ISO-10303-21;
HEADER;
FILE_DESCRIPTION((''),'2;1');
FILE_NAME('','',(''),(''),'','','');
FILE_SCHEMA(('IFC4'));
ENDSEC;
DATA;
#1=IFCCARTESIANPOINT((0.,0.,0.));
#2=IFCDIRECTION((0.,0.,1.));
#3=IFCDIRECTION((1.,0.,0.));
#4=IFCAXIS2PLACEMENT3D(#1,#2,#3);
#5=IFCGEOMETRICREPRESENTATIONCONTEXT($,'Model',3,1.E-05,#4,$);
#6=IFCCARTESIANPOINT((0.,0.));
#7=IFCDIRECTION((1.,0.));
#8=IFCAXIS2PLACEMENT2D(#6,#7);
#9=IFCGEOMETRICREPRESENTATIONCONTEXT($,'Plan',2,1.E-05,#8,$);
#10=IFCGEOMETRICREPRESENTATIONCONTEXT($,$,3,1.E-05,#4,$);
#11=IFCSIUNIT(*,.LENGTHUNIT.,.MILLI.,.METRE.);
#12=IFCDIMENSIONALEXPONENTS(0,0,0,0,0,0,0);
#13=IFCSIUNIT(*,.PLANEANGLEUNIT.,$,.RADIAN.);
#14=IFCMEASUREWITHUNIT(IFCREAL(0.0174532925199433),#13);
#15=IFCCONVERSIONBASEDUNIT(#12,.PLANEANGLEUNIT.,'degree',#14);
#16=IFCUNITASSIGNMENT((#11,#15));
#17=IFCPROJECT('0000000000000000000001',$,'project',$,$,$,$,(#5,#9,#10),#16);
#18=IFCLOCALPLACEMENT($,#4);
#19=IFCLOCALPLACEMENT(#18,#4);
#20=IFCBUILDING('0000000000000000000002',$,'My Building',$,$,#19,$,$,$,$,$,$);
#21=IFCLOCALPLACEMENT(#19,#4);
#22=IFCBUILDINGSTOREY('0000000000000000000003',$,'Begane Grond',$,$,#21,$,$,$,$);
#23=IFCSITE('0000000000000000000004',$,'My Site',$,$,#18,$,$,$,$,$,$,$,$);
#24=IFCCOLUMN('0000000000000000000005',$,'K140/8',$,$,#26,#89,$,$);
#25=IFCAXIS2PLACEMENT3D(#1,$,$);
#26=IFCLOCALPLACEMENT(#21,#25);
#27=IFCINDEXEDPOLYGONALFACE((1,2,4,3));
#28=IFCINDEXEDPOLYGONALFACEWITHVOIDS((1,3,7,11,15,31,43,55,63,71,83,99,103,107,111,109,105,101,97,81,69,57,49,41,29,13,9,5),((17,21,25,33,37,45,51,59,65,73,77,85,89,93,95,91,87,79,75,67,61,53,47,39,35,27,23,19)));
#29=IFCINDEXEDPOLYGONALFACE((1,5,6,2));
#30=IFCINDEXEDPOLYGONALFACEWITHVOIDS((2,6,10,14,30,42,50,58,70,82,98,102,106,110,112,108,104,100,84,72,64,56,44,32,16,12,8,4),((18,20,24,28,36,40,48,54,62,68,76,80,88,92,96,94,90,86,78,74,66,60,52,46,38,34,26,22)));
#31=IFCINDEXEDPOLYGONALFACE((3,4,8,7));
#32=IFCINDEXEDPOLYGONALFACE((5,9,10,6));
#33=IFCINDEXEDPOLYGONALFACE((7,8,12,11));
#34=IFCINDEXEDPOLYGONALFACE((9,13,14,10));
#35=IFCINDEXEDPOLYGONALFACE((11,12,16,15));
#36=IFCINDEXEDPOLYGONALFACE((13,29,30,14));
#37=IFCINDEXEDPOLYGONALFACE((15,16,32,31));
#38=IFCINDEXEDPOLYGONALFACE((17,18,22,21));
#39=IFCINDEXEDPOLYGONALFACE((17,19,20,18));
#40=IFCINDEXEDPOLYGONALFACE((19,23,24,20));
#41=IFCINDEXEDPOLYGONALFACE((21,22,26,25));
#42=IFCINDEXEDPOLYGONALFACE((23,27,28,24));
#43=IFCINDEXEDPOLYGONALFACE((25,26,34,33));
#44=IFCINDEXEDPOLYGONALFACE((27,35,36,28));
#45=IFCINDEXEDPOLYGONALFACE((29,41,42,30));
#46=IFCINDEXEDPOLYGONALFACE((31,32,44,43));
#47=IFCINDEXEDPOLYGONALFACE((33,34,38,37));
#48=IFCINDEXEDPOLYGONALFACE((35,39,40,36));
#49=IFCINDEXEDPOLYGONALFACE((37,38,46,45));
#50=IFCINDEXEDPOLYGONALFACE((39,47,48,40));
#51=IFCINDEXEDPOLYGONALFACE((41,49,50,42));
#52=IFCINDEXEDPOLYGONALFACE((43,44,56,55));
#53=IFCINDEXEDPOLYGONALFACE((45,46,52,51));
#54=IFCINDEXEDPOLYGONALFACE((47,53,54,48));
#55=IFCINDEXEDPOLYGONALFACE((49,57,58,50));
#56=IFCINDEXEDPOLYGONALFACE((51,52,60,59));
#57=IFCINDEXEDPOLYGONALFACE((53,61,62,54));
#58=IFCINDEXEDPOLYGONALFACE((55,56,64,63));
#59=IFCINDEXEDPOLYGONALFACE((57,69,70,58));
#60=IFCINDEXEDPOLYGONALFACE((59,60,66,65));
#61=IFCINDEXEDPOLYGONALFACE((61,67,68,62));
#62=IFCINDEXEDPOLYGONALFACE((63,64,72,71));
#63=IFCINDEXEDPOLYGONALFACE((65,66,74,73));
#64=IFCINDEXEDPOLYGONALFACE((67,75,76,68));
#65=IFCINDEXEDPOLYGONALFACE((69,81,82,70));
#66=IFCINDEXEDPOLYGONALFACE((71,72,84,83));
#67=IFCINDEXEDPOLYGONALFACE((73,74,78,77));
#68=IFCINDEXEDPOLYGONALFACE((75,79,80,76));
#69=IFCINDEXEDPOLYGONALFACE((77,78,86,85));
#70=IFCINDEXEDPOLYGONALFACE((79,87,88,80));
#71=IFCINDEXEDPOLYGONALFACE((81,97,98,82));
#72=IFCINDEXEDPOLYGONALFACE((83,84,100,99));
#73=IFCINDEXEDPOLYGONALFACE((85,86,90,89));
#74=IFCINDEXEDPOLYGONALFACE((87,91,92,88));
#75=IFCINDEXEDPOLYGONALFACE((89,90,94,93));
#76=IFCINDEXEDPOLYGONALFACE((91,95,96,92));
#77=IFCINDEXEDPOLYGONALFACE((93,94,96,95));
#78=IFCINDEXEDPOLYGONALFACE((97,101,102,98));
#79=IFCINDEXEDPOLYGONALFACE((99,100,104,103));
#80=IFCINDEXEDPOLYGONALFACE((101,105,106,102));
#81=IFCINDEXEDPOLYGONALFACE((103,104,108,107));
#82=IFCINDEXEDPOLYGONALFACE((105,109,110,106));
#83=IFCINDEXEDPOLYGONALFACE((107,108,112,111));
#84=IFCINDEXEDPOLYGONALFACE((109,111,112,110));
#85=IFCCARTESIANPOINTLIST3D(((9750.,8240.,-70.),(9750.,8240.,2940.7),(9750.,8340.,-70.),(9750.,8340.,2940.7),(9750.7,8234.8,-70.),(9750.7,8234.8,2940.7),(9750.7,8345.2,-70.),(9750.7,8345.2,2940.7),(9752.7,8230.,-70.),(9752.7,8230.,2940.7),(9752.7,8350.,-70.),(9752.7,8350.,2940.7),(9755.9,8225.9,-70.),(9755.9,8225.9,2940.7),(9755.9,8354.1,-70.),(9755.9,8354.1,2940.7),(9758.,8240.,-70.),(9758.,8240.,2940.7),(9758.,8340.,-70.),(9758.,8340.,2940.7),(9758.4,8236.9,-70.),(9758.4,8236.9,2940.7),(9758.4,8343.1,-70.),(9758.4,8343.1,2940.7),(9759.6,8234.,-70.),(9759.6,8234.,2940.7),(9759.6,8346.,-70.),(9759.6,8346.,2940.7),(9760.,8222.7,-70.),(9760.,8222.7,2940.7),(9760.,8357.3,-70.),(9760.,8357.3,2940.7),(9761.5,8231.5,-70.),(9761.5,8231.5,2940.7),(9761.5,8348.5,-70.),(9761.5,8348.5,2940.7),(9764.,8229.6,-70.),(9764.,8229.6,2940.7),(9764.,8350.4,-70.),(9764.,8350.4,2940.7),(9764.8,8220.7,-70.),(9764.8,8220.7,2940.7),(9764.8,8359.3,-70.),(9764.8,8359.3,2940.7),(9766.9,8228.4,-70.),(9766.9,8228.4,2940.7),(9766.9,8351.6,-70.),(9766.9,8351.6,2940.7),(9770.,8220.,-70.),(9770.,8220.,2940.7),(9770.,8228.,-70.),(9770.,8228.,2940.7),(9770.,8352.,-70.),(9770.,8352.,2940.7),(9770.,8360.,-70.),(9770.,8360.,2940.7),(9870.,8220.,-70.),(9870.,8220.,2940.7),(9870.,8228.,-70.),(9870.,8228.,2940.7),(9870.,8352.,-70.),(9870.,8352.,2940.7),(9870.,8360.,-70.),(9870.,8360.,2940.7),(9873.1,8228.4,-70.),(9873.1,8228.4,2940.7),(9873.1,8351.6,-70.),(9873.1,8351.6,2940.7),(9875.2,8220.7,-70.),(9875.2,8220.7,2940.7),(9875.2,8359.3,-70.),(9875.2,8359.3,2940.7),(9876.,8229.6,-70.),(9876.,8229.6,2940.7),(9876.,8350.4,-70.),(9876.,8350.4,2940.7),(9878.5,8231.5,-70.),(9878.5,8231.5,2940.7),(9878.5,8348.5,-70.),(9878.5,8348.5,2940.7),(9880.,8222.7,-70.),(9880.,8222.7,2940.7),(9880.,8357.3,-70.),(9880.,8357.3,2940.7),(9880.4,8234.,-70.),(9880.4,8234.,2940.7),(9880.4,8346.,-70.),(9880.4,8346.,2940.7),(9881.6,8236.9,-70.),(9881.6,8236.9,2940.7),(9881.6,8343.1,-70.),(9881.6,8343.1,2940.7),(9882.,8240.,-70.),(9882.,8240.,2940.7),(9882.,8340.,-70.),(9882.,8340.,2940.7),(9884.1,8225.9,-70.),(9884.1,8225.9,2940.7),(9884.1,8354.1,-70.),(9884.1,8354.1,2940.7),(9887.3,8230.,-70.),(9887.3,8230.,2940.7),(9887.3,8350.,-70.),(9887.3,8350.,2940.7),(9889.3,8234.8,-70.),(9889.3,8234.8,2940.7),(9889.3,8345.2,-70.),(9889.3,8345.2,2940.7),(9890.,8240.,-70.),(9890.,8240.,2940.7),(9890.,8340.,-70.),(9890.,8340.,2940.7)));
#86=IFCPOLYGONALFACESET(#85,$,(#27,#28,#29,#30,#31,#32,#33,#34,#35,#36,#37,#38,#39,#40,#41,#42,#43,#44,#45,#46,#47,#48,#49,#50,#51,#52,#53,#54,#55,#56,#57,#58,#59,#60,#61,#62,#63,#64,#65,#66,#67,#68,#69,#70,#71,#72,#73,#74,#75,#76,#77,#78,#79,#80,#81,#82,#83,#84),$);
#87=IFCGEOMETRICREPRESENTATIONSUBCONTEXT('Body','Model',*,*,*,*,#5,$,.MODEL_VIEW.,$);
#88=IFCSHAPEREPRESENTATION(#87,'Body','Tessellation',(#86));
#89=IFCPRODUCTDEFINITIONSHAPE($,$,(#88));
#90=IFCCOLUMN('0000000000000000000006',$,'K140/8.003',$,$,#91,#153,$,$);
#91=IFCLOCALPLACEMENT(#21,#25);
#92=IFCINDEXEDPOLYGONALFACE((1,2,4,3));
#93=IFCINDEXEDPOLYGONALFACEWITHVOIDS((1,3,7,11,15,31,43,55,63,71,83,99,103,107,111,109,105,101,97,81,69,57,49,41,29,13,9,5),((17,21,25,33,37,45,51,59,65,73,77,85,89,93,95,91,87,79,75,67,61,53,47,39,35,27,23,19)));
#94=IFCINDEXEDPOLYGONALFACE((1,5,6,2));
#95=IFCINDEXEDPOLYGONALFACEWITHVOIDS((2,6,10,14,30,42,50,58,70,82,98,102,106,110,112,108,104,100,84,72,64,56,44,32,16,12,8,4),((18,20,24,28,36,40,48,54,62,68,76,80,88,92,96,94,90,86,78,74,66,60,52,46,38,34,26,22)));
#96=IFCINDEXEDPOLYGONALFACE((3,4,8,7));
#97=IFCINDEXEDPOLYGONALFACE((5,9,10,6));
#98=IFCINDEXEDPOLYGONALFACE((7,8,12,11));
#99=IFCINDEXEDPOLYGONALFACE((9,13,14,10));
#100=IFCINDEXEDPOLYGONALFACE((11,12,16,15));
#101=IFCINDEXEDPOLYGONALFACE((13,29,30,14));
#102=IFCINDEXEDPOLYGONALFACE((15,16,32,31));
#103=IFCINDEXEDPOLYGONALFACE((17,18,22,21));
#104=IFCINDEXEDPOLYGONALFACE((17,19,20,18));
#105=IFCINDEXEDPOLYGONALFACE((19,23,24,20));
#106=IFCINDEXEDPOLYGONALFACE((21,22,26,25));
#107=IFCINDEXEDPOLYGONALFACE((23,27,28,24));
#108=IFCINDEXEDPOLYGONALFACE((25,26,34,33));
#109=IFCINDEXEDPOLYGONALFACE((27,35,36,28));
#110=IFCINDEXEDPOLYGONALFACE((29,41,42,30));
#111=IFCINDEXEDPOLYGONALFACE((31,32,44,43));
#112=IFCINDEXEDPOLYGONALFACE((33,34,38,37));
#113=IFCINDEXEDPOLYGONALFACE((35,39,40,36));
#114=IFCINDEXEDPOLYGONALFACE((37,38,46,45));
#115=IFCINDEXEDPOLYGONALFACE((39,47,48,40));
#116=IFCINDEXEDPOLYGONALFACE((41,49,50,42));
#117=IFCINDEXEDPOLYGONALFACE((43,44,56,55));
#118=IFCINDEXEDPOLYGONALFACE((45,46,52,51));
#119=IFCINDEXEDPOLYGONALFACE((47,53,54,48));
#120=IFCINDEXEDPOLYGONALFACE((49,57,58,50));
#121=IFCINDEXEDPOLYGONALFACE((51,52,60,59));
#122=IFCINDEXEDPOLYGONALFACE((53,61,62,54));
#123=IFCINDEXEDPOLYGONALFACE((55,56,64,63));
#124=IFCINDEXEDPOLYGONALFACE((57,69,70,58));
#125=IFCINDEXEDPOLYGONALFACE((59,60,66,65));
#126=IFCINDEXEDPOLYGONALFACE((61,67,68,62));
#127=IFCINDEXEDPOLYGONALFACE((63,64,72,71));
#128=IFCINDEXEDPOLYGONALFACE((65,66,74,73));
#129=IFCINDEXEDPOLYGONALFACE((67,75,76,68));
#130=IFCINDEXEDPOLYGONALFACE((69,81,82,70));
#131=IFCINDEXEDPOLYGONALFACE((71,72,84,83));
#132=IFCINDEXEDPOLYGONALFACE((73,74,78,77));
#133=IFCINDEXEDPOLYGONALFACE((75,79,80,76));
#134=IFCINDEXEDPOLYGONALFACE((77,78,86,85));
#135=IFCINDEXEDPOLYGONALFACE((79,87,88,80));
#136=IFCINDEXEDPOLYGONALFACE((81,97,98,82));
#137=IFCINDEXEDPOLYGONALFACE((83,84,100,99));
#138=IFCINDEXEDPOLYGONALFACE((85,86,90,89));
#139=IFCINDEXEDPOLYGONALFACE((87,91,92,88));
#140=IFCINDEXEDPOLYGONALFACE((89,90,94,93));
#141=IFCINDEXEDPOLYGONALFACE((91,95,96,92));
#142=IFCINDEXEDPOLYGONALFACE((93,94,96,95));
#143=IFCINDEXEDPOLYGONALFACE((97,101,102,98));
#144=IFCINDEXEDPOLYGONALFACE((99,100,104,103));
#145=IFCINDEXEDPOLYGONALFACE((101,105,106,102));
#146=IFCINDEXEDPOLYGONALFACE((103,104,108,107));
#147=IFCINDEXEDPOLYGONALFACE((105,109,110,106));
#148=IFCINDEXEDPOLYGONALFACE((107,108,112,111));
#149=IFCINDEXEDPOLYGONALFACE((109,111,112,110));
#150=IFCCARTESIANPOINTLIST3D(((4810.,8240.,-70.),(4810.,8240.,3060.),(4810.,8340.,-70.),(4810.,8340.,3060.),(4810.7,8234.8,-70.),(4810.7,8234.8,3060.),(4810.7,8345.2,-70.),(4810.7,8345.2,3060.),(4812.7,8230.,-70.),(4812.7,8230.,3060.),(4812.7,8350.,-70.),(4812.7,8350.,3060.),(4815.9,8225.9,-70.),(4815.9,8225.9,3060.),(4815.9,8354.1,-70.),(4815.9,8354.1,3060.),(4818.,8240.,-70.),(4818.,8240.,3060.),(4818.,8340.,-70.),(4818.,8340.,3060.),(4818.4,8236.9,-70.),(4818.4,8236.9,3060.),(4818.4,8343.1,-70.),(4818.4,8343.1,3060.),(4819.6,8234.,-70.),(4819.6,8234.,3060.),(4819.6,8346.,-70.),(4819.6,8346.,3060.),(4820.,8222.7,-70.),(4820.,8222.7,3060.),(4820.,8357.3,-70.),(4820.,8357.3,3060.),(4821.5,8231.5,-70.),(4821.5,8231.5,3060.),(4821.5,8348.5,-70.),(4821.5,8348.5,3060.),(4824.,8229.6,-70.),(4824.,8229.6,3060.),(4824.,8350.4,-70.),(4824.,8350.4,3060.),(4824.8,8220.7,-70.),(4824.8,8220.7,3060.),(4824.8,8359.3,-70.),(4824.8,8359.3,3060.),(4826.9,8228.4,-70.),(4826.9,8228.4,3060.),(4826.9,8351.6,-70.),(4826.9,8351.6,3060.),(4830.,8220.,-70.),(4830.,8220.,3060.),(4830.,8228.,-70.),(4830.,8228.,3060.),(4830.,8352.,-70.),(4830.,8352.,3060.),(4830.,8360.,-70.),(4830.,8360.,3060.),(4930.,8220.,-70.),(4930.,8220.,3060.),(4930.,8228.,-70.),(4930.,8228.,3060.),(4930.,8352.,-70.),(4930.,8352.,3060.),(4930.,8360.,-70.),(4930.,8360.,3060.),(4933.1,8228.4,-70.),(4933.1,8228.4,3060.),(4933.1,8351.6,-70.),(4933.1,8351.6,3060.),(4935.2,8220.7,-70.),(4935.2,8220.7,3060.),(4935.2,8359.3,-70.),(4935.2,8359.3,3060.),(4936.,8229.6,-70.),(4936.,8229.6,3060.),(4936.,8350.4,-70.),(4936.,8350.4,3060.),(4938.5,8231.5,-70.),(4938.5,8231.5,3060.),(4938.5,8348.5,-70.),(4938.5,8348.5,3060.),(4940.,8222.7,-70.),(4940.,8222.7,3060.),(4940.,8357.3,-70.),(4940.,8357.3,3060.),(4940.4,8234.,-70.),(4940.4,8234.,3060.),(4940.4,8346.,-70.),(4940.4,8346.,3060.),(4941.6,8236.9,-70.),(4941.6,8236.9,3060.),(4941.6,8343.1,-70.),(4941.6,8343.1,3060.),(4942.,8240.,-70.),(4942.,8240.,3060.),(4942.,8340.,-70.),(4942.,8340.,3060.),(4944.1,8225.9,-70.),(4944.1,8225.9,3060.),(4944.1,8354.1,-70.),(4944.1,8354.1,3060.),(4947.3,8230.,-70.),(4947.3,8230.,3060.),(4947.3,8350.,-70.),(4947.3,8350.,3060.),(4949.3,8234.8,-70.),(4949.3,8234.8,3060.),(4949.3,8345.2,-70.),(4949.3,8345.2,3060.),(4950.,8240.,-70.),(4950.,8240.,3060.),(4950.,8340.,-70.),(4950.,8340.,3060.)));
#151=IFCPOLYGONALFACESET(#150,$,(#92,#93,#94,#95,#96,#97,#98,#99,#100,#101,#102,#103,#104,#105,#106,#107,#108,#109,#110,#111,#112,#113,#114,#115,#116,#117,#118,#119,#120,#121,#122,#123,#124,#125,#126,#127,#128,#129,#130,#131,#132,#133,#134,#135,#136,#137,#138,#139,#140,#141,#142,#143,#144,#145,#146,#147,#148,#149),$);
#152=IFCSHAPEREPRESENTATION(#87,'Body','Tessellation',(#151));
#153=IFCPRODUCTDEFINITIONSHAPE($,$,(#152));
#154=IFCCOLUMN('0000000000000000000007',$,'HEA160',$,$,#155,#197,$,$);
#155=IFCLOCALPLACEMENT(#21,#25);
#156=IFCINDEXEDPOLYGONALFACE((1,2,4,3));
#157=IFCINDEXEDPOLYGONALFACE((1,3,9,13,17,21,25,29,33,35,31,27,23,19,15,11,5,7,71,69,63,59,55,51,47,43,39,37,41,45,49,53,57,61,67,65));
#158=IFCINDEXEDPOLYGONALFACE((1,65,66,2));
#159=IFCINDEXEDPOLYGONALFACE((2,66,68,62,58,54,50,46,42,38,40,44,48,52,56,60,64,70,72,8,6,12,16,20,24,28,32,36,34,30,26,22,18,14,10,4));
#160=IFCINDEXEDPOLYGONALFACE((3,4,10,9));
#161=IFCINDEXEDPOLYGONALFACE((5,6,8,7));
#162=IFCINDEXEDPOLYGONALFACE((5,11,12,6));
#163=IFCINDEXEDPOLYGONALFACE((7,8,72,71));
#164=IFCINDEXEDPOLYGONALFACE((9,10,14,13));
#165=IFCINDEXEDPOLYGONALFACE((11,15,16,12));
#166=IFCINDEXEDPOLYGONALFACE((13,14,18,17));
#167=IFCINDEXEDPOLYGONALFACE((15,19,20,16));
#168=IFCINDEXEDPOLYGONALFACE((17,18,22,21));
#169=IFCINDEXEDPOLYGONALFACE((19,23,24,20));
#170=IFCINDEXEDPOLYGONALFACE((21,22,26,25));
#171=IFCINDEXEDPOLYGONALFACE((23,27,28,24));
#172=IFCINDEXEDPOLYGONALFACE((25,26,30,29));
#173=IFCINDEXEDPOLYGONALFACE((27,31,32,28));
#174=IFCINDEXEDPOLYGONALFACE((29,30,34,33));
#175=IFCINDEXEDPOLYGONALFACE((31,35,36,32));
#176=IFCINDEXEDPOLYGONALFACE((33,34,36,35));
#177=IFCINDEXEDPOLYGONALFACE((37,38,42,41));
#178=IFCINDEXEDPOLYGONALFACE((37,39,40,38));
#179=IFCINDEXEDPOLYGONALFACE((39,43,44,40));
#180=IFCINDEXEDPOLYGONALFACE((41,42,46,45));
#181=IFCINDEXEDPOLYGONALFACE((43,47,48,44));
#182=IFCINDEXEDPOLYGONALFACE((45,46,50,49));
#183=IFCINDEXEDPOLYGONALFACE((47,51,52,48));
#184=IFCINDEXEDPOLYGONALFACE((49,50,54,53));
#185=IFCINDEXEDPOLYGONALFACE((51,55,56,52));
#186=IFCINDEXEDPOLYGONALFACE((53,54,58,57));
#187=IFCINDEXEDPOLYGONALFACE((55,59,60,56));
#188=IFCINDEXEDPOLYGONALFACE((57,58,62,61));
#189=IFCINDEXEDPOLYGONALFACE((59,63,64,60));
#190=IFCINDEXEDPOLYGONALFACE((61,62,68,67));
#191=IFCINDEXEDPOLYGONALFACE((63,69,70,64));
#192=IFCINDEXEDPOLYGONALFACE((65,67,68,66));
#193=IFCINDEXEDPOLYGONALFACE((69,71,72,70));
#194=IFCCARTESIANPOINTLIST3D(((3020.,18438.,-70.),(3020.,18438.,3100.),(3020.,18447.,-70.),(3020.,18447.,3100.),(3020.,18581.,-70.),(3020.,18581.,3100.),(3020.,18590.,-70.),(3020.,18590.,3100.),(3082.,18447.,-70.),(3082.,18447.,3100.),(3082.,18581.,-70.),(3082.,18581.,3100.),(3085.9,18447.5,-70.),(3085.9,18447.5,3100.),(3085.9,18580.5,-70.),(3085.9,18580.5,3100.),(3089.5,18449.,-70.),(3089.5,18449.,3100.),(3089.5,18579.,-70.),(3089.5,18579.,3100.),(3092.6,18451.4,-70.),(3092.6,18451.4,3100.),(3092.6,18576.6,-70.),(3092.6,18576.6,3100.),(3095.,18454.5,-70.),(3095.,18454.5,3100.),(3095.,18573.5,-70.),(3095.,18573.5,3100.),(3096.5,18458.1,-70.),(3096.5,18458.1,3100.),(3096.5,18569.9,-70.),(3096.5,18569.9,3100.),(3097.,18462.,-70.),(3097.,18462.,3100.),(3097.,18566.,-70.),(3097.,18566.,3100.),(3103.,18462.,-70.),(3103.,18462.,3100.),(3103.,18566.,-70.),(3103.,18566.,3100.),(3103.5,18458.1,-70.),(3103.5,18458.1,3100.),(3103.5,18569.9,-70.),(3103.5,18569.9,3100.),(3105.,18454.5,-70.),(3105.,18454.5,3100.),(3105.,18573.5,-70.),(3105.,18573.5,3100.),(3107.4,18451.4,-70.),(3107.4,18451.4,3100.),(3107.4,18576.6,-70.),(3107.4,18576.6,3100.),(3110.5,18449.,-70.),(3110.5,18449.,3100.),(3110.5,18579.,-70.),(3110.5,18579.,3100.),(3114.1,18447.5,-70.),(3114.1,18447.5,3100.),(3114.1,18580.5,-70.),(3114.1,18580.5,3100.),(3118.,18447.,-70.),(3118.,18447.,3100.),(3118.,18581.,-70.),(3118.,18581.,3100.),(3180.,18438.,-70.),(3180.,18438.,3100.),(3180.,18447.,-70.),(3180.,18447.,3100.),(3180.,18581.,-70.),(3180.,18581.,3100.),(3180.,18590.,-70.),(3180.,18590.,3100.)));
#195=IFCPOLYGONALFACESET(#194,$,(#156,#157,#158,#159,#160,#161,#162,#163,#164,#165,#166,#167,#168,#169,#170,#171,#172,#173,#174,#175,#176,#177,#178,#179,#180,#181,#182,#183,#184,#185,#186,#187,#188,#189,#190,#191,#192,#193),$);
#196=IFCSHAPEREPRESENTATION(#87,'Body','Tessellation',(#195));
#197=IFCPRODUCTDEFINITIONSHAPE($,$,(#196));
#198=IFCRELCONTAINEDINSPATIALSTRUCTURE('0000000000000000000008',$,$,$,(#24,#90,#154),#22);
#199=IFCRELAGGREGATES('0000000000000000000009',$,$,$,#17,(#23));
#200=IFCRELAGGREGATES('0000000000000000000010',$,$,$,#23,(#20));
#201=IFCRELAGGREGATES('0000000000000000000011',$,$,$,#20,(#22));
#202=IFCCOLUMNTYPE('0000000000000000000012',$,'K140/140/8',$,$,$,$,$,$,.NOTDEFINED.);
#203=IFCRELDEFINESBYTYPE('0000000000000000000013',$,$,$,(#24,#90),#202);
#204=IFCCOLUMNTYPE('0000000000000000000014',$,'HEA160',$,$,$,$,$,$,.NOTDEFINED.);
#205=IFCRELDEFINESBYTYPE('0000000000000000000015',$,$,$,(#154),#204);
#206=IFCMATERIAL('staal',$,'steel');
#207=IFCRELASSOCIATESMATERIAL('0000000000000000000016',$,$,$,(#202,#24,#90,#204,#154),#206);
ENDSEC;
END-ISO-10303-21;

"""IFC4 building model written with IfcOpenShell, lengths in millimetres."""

from ifc_helpers import new_model, entity, si_unit, converted_unit, frame, origin_with_axes, origin_2d_with_axis, place, context, subcontext, project, spatial, hollow_rectangle, i_section, extrude, material, material_profile, profile_set, profile_usage, type_object, element, save


model = new_model("IFC4")

# Units and contexts
model_context = context("Model", 3, precision=1e-05, world=origin_with_axes())
plan_context = context("Plan", 2, precision=1e-05, world=origin_2d_with_axis())
context_of_model = context(None, 3, precision=1e-05, world=origin_with_axes())
body_context = subcontext(model_context, "Body", "Model", "MODEL_VIEW")
ifc_project = project(units=[si_unit("LENGTHUNIT", "METRE", prefix="MILLI"), converted_unit("PLANEANGLEUNIT", "degree", entity("IfcReal", 0.0174532925199433), si_unit("PLANEANGLEUNIT", "RADIAN"), dimensions=[0, 0, 0, 0, 0, 0, 0])], contexts=[model_context, plan_context, context_of_model])

# Site, building, storey
site_placement = place(None, origin_with_axes())
site = spatial("IfcSite", under=ifc_project, at=site_placement, Name="My Site")
building_placement = place(site_placement, origin_with_axes())
building = spatial("IfcBuilding", under=site, at=building_placement, Name="My Building")
storey_placement = place(building_placement, origin_with_axes())
storey = spatial("IfcBuildingStorey", under=building, at=storey_placement, Name="Begane Grond")

# Columns
ifc_material = material(Name="staal", Category="steel")
ifc_material_profile_1 = material_profile(ifc_material, hollow_rectangle(XDim=140.0, YDim=140.0, WallThickness=8.0, InnerFilletRadius=12.0, OuterFilletRadius=20.0))
ifc_profile_set_1 = profile_set([ifc_material_profile_1], Name="K140/140/8")
column_type_1 = type_object("IfcColumnType", Name="K140/140/8", PredefinedType="NOTDEFINED", material=ifc_profile_set_1)
ifc_profile_usage_1 = profile_usage(ifc_profile_set_1, cardinal=5)
column_1_placement = place(storey_placement, frame((9820.0, 8290.0, -70.0), z_axis=(0.0, 0.0, 1.0), x_axis=(1.0, 0.0, 0.0)))
element("IfcColumn", 1, at=column_1_placement, inside=storey, type_object=column_type_1, material=ifc_profile_usage_1, Name="K140/8", context=body_context, shape_type="SweptSolid", body=[
    extrude(hollow_rectangle(XDim=140.0, YDim=140.0, WallThickness=8.0, InnerFilletRadius=12.0, OuterFilletRadius=20.0), origin_with_axes(), (0.0, 0.0, 1.0), 3010.7),
])
ifc_profile_usage_2 = profile_usage(ifc_profile_set_1, cardinal=5)
column_2_placement = place(storey_placement, frame((4880.0, 8290.0, -70.0), z_axis=(0.0, 0.0, 1.0), x_axis=(1.0, 0.0, 0.0)))
element("IfcColumn", 2, at=column_2_placement, inside=storey, type_object=column_type_1, material=ifc_profile_usage_2, Name="K140/8.003", context=body_context, shape_type="SweptSolid", body=[
    extrude(hollow_rectangle(XDim=140.0, YDim=140.0, WallThickness=8.0, InnerFilletRadius=12.0, OuterFilletRadius=20.0), origin_with_axes(), (0.0, 0.0, 1.0), 3130.0),
])
ifc_material_profile_2 = material_profile(ifc_material, i_section(OverallWidth=160.0, OverallDepth=152.0, WebThickness=6.0, FlangeThickness=9.0, FilletRadius=15.0))
ifc_profile_set_2 = profile_set([ifc_material_profile_2], Name="HEA160")
ifc_profile_usage_3 = profile_usage(ifc_profile_set_2)
column_type_2 = type_object("IfcColumnType", Name="HEA160", PredefinedType="NOTDEFINED", material=ifc_profile_set_2)
column_3_placement = place(storey_placement, frame((3100.0, 18514.0, -70.0), z_axis=(0.0, 0.0, 1.0), x_axis=(1.0, 0.0, 0.0)))
element("IfcColumn", 3, at=column_3_placement, inside=storey, type_object=column_type_2, material=ifc_profile_usage_3, Name="HEA160", context=body_context, shape_type="SweptSolid", body=[
    extrude(i_section(OverallWidth=160.0, OverallDepth=152.0, WebThickness=6.0, FlangeThickness=9.0, FilletRadius=15.0), origin_with_axes(), (0.0, 0.0, 1.0), 3170.0),
])

save(model, "model.ifc")
